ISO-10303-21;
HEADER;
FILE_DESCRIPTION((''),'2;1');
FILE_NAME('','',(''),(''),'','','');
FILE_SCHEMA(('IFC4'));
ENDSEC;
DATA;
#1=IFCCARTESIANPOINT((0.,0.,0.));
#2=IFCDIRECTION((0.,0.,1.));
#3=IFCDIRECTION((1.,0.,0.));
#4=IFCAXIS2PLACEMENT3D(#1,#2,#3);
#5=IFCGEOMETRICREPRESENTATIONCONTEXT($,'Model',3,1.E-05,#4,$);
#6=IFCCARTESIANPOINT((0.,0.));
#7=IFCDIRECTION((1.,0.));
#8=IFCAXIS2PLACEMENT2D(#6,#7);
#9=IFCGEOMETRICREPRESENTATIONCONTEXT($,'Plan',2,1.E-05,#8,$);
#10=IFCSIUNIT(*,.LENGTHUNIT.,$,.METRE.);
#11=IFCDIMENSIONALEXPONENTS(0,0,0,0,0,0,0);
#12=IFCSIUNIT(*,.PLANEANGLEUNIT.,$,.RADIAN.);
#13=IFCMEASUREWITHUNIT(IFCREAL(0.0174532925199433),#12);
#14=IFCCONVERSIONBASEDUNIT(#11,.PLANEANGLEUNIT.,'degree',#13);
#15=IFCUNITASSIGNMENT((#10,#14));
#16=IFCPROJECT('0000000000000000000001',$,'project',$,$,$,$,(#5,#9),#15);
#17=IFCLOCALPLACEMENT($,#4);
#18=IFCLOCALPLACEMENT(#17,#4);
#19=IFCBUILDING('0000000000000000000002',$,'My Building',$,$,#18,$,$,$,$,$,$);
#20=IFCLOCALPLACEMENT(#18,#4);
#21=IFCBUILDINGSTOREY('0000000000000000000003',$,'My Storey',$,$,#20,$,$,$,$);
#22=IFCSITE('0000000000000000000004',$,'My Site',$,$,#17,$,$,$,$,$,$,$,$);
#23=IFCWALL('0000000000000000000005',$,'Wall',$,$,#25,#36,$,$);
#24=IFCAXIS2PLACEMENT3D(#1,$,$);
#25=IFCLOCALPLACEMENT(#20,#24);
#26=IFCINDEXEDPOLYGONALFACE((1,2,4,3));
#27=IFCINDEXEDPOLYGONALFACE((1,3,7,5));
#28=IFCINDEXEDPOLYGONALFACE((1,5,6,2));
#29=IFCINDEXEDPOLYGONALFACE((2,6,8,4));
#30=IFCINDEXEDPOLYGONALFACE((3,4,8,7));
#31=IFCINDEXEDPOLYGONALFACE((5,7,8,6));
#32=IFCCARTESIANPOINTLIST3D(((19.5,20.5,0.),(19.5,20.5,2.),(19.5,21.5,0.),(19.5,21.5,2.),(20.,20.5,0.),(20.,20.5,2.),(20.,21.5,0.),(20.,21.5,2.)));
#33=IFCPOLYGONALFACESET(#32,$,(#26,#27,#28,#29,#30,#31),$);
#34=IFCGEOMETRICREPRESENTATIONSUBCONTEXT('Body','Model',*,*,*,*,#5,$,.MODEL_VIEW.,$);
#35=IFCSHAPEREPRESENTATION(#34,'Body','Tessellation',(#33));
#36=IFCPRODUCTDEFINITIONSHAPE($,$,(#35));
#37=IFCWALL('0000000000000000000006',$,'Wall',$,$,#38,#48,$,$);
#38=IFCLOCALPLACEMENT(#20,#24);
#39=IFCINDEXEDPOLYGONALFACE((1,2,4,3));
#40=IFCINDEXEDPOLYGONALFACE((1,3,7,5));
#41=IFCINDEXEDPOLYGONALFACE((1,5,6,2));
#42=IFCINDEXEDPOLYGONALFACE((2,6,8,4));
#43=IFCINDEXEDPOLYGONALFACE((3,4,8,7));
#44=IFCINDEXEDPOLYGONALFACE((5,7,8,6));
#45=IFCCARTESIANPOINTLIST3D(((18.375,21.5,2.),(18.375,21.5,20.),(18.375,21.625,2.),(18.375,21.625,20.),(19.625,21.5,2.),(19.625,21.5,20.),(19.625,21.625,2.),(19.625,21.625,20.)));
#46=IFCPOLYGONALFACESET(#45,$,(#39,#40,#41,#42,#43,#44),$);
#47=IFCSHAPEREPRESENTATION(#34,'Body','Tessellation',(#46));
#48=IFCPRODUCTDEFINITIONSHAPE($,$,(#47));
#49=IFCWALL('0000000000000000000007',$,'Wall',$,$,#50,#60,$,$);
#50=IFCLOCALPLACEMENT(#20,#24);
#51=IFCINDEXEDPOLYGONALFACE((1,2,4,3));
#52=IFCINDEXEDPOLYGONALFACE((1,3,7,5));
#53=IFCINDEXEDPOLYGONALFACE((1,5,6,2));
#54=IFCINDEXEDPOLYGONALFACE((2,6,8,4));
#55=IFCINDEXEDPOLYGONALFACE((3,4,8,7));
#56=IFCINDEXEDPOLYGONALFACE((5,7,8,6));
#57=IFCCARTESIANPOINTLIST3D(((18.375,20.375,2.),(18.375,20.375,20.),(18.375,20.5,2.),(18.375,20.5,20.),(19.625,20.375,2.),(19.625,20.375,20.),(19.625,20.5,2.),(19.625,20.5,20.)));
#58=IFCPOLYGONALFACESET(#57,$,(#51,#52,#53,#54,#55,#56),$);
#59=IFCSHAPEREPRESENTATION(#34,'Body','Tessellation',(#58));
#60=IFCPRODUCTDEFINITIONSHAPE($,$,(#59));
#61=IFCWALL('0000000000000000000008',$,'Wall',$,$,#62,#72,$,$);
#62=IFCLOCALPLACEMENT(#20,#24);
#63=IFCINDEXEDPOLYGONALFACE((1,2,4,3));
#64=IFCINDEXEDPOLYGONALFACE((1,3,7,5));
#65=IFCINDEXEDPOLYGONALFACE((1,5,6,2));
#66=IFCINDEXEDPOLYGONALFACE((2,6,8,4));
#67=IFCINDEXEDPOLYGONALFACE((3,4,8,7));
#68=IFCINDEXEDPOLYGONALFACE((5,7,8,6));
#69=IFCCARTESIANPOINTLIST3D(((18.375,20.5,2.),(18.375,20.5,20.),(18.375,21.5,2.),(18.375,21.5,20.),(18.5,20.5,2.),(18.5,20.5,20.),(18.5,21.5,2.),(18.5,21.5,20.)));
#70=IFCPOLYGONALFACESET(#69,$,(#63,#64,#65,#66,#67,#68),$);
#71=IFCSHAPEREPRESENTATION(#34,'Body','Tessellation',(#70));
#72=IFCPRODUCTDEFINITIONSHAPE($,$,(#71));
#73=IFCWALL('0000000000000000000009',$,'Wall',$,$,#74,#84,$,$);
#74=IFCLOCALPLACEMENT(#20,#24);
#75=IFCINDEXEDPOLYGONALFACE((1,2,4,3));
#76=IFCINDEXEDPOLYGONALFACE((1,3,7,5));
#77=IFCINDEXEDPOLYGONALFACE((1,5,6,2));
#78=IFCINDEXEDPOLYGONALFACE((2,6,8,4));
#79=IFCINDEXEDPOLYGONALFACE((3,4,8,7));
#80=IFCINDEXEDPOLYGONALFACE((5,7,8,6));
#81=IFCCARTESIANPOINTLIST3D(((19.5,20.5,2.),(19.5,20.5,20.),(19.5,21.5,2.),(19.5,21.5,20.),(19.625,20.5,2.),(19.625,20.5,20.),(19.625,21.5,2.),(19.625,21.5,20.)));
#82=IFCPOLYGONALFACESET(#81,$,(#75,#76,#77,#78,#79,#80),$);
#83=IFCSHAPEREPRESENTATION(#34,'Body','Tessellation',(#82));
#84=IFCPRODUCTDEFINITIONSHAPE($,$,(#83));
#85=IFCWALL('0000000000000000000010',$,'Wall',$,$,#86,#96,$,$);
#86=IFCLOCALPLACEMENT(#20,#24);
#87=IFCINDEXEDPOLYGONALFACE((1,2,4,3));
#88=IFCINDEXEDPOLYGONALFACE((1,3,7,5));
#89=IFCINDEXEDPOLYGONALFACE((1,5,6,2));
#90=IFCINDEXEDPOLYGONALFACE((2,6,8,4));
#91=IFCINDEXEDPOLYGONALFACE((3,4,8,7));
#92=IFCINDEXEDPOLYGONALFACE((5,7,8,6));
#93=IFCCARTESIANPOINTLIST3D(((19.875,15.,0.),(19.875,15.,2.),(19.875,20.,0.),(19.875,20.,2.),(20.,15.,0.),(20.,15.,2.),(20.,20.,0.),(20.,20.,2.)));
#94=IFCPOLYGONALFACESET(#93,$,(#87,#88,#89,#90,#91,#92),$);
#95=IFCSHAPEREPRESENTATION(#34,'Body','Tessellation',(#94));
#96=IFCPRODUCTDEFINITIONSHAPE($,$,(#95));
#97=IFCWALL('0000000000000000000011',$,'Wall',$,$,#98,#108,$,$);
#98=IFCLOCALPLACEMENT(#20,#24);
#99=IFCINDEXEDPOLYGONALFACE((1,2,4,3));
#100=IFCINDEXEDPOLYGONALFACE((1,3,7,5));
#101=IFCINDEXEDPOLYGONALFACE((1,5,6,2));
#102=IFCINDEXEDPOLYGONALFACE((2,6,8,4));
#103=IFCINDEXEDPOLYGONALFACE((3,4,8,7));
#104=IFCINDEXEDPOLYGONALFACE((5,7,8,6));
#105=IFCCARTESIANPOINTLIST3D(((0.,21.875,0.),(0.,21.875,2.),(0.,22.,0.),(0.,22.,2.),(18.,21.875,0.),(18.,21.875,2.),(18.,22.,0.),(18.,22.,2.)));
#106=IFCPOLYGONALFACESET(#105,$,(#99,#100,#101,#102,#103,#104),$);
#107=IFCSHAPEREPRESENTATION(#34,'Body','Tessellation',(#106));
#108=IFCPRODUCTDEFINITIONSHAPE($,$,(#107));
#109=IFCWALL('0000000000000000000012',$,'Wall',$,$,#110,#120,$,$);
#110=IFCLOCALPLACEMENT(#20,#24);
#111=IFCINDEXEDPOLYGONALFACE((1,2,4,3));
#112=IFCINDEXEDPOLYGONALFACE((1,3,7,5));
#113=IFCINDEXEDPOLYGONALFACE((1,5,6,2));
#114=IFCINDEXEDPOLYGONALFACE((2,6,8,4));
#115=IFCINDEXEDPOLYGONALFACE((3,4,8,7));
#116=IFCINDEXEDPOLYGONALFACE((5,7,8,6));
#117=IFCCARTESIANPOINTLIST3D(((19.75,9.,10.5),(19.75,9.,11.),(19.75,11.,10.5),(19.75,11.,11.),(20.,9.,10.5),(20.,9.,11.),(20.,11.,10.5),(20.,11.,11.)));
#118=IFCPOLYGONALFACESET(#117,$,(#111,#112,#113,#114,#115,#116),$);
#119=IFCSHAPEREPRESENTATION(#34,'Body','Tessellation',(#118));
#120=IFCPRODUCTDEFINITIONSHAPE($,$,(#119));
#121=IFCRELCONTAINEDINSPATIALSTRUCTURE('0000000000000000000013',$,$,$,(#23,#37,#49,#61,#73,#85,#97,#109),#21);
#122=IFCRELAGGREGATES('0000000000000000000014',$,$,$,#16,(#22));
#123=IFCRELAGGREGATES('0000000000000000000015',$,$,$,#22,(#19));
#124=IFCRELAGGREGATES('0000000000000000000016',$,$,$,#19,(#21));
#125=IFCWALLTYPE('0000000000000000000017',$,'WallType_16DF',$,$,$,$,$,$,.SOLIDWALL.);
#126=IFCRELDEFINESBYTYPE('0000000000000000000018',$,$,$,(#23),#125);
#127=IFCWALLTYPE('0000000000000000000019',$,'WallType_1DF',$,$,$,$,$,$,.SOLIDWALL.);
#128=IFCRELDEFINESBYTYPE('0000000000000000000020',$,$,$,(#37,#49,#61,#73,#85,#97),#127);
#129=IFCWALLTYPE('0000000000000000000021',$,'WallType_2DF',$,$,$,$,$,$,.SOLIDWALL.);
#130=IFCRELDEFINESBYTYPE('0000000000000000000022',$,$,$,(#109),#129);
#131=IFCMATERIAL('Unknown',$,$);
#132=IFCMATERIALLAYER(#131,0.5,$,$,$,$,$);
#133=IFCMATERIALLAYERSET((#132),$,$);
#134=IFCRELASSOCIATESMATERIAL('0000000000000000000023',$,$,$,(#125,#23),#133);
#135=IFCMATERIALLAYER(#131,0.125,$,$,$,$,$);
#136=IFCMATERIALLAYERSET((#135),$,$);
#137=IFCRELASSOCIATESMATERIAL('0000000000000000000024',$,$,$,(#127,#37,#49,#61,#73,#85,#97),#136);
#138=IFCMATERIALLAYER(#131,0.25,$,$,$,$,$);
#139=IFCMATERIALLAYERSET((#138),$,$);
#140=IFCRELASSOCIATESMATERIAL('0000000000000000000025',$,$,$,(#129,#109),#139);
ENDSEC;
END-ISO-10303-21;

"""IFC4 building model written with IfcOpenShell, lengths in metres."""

from ifc_helpers import new_model, entity, si_unit, converted_unit, frame, origin_with_axes, origin_2d_with_axis, place, context, subcontext, project, spatial, indexed_curve, outline, extrude, material, layer, layer_set, layer_usage, type_object, element, save


model = new_model("IFC4")

# Units and contexts
model_context = context("Model", 3, precision=1e-05, world=origin_with_axes())
plan_context = context("Plan", 2, precision=1e-05, world=origin_2d_with_axis())
body_context_1 = subcontext(model_context, "Body", "Model", "MODEL_VIEW")
ifc_project = project(units=[si_unit("LENGTHUNIT", "METRE"), converted_unit("PLANEANGLEUNIT", "degree", entity("IfcReal", 0.0174532925199433), si_unit("PLANEANGLEUNIT", "RADIAN"), dimensions=[0, 0, 0, 0, 0, 0, 0])], contexts=[model_context, plan_context])

# Site, building, storey
site_placement = place(None, origin_with_axes())
site = spatial("IfcSite", under=ifc_project, at=site_placement, Name="My Site")
building_placement = place(site_placement, origin_with_axes())
building = spatial("IfcBuilding", under=site, at=building_placement, Name="My Building")
storey_placement = place(building_placement, origin_with_axes())
storey = spatial("IfcBuildingStorey", under=building, at=storey_placement, Name="My Storey")

# Walls
ifc_material = material(Name="Unknown")
ifc_layer_1 = layer(ifc_material, 0.5)
ifc_layer_set_1 = layer_set([ifc_layer_1])
ifc_layer_usage_1 = layer_usage(ifc_layer_set_1, "AXIS2", "POSITIVE", 0.0)
wall_type_1 = type_object("IfcWallType", Name="WallType_16DF", PredefinedType="SOLIDWALL", material=ifc_layer_set_1)
wall_1_placement = place(storey_placement, frame((20.0, 20.5, 0.0), z_axis=(0.0, 0.0, 1.0), x_axis=(0.0, 1.0, 0.0)))
element("IfcWall", 1, at=wall_1_placement, inside=storey, type_object=wall_type_1, material=ifc_layer_usage_1, Name="Wall", context=body_context_1, shape_type="SweptSolid", body=[
    extrude(outline(indexed_curve([(0.0, 0.0), (0.0, 0.5), (1.0, 0.5), (1.0, 0.0), (0.0, 0.0)], self_intersect=False)), origin_with_axes(), (0.0, 0.0, 1.0), 2.0),
])
ifc_layer_2 = layer(ifc_material, 0.125)
ifc_layer_set_2 = layer_set([ifc_layer_2])
ifc_layer_usage_2 = layer_usage(ifc_layer_set_2, "AXIS2", "POSITIVE", 0.0)
wall_type_2 = type_object("IfcWallType", Name="WallType_1DF", PredefinedType="SOLIDWALL", material=ifc_layer_set_2)
wall_2_placement = place(storey_placement, frame((18.375, 21.5, 2.0), z_axis=(0.0, 0.0, 1.0), x_axis=(1.0, 0.0, 0.0)))
element("IfcWall", 2, at=wall_2_placement, inside=storey, type_object=wall_type_2, material=ifc_layer_usage_2, Name="Wall", context=body_context_1, shape_type="SweptSolid", body=[
    extrude(outline(indexed_curve([(0.0, 0.0), (0.0, 0.125), (1.25, 0.125), (1.25, 0.0), (0.0, 0.0)], self_intersect=False)), origin_with_axes(), (0.0, 0.0, 1.0), 18.0),
])
ifc_layer_usage_3 = layer_usage(ifc_layer_set_2, "AXIS2", "POSITIVE", 0.0)
wall_3_placement = place(storey_placement, frame((18.375, 20.375, 2.0), z_axis=(0.0, 0.0, 1.0), x_axis=(1.0, 0.0, 0.0)))
element("IfcWall", 3, at=wall_3_placement, inside=storey, type_object=wall_type_2, material=ifc_layer_usage_3, Name="Wall", context=body_context_1, shape_type="SweptSolid", body=[
    extrude(outline(indexed_curve([(0.0, 0.0), (0.0, 0.125), (1.25, 0.125), (1.25, 0.0), (0.0, 0.0)], self_intersect=False)), origin_with_axes(), (0.0, 0.0, 1.0), 18.0),
])
ifc_layer_usage_4 = layer_usage(ifc_layer_set_2, "AXIS2", "POSITIVE", 0.0)
wall_4_placement = place(storey_placement, frame((18.5, 20.5, 2.0), z_axis=(0.0, 0.0, 1.0), x_axis=(0.0, 1.0, 0.0)))
element("IfcWall", 4, at=wall_4_placement, inside=storey, type_object=wall_type_2, material=ifc_layer_usage_4, Name="Wall", context=body_context_1, shape_type="SweptSolid", body=[
    extrude(outline(indexed_curve([(0.0, 0.0), (0.0, 0.125), (1.0, 0.125), (1.0, 0.0), (0.0, 0.0)], self_intersect=False)), origin_with_axes(), (0.0, 0.0, 1.0), 18.0),
])
ifc_layer_usage_5 = layer_usage(ifc_layer_set_2, "AXIS2", "POSITIVE", 0.0)
wall_5_placement = place(storey_placement, frame((19.625, 20.5, 2.0), z_axis=(0.0, 0.0, 1.0), x_axis=(0.0, 1.0, 0.0)))
element("IfcWall", 5, at=wall_5_placement, inside=storey, type_object=wall_type_2, material=ifc_layer_usage_5, Name="Wall", context=body_context_1, shape_type="SweptSolid", body=[
    extrude(outline(indexed_curve([(0.0, 0.0), (0.0, 0.125), (1.0, 0.125), (1.0, 0.0), (0.0, 0.0)], self_intersect=False)), origin_with_axes(), (0.0, 0.0, 1.0), 18.0),
])
ifc_layer_usage_6 = layer_usage(ifc_layer_set_2, "AXIS2", "POSITIVE", 0.0)
wall_6_placement = place(storey_placement, frame((20.0, 15.0, 0.0), z_axis=(0.0, 0.0, 1.0), x_axis=(0.0, 1.0, 0.0)))
element("IfcWall", 6, at=wall_6_placement, inside=storey, type_object=wall_type_2, material=ifc_layer_usage_6, Name="Wall", context=body_context_1, shape_type="SweptSolid", body=[
    extrude(outline(indexed_curve([(0.0, 0.0), (0.0, 0.125), (5.0, 0.125), (5.0, 0.0), (0.0, 0.0)], self_intersect=False)), origin_with_axes(), (0.0, 0.0, 1.0), 2.0),
])
ifc_layer_usage_7 = layer_usage(ifc_layer_set_2, "AXIS2", "POSITIVE", 0.0)
wall_7_placement = place(storey_placement, frame((18.0, 22.0, 0.0), z_axis=(0.0, 0.0, 1.0), x_axis=(-1.0, 0.0, 0.0)))
element("IfcWall", 7, at=wall_7_placement, inside=storey, type_object=wall_type_2, material=ifc_layer_usage_7, Name="Wall", context=body_context_1, shape_type="SweptSolid", body=[
    extrude(outline(indexed_curve([(0.0, 0.0), (0.0, 0.125), (18.0, 0.125), (18.0, 0.0), (0.0, 0.0)], self_intersect=False)), origin_with_axes(), (0.0, 0.0, 1.0), 2.0),
])

# Shared definitions
ifc_layer_3 = layer(ifc_material, 0.25)
ifc_layer_set_3 = layer_set([ifc_layer_3])
wall_type_3 = type_object("IfcWallType", Name="WallType_2DF", PredefinedType="SOLIDWALL", material=ifc_layer_set_3)

# Wall
ifc_layer_usage_8 = layer_usage(ifc_layer_set_3, "AXIS2", "POSITIVE", 0.0)
wall_8_placement = place(storey_placement, frame((20.0, 9.0, 10.5), z_axis=(0.0, 0.0, 1.0), x_axis=(0.0, 1.0, 0.0)))
element("IfcWall", 8, at=wall_8_placement, inside=storey, type_object=wall_type_3, material=ifc_layer_usage_8, Name="Wall", context=body_context_1, shape_type="SweptSolid", body=[
    extrude(outline(indexed_curve([(0.0, 0.0), (0.0, 0.25), (2.0, 0.25), (2.0, 0.0), (0.0, 0.0)], self_intersect=False)), origin_with_axes(), (0.0, 0.0, 1.0), 0.5),
])

save(model, "model.ifc")
